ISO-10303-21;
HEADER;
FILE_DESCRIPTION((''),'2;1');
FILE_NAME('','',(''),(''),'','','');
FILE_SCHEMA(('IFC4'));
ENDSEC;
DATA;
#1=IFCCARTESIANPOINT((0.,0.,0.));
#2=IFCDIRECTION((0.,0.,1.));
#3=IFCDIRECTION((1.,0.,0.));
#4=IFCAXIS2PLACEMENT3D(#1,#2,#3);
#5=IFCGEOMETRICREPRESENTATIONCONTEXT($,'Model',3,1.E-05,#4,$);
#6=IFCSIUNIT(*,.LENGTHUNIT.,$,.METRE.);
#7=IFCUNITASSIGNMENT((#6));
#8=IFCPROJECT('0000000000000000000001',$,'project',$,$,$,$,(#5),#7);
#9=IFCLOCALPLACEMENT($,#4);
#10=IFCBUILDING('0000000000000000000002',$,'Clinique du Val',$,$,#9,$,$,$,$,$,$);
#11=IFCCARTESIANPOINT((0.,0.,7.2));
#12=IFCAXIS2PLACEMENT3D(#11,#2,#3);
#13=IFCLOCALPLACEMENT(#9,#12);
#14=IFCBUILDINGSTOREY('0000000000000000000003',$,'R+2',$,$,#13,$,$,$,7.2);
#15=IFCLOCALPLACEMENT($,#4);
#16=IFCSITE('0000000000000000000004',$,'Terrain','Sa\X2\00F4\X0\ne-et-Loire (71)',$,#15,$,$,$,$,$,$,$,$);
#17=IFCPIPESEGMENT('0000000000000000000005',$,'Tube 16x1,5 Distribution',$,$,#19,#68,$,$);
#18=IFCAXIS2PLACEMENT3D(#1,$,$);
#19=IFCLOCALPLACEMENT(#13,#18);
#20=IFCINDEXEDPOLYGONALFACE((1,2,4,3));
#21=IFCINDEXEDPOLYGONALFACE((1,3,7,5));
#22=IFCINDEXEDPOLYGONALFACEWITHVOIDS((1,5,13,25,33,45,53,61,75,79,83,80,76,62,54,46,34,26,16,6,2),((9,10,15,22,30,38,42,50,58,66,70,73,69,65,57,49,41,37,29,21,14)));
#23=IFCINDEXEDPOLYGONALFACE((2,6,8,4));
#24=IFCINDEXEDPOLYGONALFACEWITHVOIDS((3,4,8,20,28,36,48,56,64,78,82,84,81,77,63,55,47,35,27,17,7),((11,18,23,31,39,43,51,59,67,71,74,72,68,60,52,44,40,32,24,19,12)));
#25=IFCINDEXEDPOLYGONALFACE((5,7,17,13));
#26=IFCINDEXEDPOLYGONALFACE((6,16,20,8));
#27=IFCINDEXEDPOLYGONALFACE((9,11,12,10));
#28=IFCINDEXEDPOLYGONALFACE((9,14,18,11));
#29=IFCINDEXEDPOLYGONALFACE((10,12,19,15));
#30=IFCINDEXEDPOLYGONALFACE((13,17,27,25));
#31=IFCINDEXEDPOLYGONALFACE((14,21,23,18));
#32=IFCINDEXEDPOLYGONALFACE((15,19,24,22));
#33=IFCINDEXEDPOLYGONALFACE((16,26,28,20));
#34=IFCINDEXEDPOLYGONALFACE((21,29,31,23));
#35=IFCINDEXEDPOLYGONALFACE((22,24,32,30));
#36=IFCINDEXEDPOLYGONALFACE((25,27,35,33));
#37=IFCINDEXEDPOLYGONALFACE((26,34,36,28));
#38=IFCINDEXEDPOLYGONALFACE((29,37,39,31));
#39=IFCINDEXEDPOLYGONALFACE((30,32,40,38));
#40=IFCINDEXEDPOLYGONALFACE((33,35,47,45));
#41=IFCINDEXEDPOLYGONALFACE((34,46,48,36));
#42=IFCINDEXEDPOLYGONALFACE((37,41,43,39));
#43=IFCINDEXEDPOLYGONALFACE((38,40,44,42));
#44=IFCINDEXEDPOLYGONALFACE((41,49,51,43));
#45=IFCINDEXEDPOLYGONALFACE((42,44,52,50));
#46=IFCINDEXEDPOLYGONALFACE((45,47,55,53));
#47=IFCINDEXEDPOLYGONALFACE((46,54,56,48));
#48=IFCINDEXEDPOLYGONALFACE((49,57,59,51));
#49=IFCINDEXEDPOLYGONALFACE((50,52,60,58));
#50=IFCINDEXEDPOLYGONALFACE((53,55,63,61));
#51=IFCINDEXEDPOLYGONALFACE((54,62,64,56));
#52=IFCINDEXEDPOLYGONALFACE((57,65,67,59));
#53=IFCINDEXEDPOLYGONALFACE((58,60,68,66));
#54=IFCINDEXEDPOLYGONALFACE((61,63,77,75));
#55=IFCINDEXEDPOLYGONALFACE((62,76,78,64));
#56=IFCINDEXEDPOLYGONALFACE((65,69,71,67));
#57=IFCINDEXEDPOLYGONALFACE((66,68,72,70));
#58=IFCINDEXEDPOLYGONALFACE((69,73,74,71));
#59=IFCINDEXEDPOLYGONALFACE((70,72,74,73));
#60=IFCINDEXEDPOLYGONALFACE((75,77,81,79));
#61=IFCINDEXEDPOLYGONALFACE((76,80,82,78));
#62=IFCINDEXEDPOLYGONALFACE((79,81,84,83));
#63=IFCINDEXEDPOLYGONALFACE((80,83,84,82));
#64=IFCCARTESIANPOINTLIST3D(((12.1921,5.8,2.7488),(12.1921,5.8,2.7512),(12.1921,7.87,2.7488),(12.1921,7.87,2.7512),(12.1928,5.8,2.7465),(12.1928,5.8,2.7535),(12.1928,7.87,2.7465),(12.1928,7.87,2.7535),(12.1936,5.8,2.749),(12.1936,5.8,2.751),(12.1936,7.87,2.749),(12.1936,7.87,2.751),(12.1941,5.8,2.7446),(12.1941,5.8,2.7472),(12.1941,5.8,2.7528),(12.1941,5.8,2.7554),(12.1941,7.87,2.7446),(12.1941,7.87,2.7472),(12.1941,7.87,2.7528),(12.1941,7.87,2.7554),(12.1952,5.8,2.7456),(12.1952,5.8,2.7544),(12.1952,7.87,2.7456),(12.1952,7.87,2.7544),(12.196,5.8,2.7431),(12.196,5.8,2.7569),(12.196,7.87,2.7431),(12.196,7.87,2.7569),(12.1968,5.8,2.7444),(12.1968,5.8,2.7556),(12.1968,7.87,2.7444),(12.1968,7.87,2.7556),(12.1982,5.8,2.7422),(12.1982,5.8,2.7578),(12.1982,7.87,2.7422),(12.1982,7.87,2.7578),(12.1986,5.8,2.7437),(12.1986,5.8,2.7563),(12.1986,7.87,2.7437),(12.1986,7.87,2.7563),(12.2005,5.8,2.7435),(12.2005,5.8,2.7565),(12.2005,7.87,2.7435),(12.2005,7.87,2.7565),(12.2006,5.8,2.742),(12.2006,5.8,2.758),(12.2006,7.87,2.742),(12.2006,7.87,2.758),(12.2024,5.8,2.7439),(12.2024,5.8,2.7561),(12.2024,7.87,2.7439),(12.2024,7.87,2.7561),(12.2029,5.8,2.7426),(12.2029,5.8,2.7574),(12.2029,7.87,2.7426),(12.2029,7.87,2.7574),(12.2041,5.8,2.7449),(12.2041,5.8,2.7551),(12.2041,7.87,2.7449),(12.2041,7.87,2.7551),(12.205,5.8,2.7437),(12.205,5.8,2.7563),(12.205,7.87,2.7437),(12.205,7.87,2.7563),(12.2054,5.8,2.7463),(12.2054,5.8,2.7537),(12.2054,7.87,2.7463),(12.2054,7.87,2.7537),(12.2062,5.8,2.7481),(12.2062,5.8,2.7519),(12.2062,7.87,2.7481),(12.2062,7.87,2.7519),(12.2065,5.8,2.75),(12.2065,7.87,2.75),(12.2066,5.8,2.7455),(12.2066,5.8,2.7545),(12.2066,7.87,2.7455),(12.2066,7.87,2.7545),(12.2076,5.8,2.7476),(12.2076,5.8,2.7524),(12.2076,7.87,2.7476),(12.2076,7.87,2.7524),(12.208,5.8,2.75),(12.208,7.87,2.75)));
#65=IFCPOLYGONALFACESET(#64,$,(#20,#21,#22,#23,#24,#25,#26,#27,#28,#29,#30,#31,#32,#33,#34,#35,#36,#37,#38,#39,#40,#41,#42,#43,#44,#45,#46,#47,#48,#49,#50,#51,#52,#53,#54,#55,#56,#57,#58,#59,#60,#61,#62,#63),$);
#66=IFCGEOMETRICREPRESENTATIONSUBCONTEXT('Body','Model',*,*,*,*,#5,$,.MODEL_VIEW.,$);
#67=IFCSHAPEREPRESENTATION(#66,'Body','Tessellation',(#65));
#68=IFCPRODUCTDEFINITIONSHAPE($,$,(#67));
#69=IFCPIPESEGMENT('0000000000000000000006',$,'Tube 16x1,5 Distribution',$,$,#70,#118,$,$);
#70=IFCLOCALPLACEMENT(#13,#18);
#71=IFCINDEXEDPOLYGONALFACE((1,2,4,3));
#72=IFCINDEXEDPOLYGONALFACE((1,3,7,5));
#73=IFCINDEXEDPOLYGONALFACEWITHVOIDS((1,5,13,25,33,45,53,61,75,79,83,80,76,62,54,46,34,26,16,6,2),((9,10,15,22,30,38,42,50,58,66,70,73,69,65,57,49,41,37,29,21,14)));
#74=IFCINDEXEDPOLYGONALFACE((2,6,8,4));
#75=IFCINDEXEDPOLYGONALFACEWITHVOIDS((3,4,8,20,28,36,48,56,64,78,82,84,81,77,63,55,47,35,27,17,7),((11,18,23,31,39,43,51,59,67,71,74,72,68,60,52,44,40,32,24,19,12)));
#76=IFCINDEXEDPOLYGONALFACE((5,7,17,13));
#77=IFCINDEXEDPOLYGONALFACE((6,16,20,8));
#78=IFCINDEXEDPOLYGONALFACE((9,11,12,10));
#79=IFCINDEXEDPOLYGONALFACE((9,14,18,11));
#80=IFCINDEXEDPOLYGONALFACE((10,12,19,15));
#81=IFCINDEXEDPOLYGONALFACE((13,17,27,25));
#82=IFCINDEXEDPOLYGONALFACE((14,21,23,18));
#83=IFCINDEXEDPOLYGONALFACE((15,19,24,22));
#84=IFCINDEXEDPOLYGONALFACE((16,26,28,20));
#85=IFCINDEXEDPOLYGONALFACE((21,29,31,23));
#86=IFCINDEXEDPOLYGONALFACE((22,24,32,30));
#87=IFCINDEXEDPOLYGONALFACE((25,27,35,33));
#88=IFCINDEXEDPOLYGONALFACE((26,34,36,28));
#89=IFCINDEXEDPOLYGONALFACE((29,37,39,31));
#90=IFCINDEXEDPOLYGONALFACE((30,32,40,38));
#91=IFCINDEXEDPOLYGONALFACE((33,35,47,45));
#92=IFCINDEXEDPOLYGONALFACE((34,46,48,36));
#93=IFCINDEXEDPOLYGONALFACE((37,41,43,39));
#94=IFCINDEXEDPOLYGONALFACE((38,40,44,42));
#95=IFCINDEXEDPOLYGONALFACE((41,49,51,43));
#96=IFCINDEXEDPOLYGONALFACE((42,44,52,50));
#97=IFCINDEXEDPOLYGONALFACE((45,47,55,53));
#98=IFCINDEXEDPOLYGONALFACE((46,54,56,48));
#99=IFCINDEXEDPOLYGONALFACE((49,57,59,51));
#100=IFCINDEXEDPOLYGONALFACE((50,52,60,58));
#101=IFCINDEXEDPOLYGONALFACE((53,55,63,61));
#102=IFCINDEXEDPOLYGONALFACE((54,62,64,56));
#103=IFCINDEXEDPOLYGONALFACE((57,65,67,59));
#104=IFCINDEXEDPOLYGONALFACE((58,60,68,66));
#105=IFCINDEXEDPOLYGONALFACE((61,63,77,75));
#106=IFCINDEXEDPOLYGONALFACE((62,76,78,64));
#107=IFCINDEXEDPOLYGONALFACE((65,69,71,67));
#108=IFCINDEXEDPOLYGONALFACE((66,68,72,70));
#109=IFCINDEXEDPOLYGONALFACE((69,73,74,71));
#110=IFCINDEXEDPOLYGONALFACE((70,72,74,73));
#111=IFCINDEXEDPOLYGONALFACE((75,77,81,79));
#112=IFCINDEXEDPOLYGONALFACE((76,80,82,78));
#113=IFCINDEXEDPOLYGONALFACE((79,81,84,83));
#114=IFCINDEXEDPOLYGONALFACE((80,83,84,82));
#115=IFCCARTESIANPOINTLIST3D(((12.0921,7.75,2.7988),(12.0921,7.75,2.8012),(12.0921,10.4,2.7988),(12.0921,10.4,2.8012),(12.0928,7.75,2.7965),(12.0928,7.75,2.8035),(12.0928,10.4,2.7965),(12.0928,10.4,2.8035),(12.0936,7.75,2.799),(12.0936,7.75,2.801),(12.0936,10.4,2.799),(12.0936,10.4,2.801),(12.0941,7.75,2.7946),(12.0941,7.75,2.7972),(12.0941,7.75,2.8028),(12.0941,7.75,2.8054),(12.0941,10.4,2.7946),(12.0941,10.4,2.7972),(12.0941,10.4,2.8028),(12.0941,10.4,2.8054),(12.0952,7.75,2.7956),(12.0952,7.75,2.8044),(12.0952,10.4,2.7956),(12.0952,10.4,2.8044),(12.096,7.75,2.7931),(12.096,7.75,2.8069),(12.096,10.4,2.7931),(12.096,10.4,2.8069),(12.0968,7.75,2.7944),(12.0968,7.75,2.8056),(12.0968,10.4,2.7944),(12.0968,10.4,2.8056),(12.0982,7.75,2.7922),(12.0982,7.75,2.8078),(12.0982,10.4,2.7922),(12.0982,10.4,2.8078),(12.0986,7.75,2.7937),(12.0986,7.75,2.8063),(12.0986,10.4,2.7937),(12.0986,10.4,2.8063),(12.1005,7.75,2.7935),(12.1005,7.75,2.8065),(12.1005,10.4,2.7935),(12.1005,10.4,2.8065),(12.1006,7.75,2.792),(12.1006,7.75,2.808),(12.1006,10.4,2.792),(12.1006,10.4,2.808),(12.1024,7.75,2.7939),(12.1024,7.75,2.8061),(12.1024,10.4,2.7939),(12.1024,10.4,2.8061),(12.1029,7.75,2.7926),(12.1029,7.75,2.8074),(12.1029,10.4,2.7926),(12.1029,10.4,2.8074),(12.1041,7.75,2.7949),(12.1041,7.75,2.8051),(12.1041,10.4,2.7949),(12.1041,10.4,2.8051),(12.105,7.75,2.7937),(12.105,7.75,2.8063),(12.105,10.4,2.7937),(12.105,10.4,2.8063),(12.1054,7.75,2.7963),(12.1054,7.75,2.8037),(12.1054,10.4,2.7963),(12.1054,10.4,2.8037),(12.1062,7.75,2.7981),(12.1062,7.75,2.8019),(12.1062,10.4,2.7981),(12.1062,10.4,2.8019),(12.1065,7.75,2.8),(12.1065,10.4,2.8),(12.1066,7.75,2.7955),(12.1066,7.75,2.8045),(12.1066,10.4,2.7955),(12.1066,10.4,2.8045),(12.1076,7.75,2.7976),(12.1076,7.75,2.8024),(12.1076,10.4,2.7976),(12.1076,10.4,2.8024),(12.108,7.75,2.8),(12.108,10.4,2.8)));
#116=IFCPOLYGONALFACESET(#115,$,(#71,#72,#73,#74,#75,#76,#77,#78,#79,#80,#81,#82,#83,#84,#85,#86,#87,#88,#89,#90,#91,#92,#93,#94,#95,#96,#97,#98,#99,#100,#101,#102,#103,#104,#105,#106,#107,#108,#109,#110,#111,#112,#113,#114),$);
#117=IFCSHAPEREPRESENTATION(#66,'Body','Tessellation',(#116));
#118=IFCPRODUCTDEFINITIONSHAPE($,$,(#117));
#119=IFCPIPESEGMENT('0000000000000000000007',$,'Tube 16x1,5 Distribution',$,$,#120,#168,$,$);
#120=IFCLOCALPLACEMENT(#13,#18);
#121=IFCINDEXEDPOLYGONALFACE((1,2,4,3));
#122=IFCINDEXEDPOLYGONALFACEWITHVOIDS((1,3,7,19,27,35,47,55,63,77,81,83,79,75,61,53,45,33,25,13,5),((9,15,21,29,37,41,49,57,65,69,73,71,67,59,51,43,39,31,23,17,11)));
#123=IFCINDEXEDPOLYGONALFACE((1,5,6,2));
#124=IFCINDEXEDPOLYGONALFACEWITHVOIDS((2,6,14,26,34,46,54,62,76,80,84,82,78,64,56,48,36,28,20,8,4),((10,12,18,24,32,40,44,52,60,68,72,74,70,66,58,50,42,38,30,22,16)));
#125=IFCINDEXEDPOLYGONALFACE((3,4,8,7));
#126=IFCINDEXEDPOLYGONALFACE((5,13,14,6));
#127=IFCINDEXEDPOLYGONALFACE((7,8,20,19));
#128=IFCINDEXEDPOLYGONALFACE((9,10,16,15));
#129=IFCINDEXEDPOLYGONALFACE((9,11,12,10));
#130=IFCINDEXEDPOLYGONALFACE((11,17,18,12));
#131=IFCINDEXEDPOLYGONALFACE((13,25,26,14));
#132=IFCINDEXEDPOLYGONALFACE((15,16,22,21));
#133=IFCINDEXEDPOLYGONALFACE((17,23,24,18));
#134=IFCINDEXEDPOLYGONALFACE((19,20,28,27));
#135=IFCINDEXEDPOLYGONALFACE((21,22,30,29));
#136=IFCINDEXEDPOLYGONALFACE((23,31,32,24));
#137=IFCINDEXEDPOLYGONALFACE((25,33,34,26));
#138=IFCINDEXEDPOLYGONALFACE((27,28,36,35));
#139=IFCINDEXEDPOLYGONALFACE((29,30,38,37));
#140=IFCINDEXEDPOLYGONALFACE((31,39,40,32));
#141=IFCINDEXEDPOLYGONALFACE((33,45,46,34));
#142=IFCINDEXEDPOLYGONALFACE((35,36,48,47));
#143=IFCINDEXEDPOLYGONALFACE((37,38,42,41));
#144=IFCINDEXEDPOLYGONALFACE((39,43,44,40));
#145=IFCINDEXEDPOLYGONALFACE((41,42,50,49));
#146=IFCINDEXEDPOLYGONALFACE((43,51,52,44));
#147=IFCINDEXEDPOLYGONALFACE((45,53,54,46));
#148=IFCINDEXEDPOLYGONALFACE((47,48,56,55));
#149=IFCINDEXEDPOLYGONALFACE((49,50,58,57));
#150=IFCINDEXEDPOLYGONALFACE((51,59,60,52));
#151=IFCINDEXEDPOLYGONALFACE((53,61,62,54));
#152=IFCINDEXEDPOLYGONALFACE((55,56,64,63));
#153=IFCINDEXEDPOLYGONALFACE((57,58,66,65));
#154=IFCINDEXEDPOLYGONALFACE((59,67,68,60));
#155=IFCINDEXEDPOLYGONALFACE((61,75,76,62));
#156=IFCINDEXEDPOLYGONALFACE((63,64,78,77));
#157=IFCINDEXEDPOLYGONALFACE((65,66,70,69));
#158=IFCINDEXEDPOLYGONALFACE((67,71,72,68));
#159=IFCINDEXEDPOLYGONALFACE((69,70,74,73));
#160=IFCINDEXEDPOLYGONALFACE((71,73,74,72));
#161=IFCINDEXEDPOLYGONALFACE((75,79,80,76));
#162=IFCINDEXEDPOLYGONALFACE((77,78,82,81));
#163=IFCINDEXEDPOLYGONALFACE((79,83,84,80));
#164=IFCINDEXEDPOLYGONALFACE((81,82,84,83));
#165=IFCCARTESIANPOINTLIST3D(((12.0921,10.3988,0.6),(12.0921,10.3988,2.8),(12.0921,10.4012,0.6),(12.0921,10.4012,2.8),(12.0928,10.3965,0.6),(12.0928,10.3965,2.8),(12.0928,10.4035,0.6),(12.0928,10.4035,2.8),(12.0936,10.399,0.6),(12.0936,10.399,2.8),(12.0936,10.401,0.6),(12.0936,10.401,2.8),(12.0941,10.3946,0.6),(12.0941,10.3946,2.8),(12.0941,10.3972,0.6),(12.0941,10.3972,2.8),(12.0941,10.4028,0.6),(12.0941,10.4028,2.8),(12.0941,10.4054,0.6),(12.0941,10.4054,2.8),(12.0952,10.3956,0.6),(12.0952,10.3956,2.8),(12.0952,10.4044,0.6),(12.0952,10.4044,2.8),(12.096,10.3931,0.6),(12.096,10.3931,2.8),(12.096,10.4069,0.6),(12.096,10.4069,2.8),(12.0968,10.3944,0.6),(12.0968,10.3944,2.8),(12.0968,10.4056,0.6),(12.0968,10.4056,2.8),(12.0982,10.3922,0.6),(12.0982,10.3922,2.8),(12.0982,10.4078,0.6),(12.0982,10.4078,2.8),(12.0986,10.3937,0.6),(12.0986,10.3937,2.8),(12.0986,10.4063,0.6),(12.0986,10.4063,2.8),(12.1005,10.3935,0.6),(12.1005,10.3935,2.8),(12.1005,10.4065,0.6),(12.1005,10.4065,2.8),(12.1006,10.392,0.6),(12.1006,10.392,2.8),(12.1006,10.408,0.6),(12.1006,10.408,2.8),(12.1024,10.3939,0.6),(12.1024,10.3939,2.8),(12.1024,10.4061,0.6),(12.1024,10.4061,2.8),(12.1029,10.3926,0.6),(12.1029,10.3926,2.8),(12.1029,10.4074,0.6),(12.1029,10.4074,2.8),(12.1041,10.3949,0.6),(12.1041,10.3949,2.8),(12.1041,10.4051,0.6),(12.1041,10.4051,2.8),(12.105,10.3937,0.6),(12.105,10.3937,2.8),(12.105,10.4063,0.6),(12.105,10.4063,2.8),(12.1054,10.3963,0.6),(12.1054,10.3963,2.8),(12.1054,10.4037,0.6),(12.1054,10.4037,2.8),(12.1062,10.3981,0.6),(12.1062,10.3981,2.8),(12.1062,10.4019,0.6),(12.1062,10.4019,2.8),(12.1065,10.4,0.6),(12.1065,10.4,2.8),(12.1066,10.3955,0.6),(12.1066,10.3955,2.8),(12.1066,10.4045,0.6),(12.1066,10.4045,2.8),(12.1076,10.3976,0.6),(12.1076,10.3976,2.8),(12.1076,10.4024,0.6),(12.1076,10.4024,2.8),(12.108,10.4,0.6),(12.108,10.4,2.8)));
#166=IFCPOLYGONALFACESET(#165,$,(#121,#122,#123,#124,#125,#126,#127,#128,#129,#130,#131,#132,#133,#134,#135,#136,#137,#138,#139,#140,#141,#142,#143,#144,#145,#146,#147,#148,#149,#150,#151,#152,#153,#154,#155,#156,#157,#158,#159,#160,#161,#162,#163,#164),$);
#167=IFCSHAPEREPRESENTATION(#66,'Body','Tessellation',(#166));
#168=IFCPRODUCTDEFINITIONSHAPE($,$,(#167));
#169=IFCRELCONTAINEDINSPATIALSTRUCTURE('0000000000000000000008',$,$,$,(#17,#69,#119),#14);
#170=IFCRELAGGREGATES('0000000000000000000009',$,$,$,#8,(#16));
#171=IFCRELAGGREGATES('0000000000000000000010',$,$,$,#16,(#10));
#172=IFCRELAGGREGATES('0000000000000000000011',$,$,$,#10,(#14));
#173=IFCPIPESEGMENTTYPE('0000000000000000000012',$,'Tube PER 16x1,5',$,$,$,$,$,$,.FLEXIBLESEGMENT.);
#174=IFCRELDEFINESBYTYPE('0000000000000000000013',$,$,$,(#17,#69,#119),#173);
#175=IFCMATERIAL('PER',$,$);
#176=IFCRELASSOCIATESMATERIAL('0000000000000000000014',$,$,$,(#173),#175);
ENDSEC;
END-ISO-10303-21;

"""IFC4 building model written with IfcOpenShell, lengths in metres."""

from ifc_helpers import new_model, si_unit, frame, origin_with_axes, place, context, subcontext, project, spatial, hollow_circle, extrude, material, type_object, element, save


model = new_model("IFC4")

# Units and contexts
model_context = context("Model", 3, precision=1e-05, world=origin_with_axes())
body_context = subcontext(model_context, "Body", "Model", "MODEL_VIEW")
ifc_project = project(units=[si_unit("LENGTHUNIT", "METRE")], contexts=[model_context])

# Site, building, storey
site_placement = place(None, origin_with_axes())
site = spatial("IfcSite", under=ifc_project, at=site_placement, Name="Terrain", Description="Saône-et-Loire (71)")
building_placement = place(None, origin_with_axes())
building = spatial("IfcBuilding", under=site, at=building_placement, Name="Clinique du Val")
storey_placement = place(building_placement, frame((0.0, 0.0, 7.2), z_axis=(0.0, 0.0, 1.0), x_axis=(1.0, 0.0, 0.0)))
storey = spatial("IfcBuildingStorey", under=building, at=storey_placement, Name="R+2", Elevation=7.2)

# Pipe segments
ifc_material_1 = material(Name="PER")
pipe_segment_type_1 = type_object("IfcPipeSegmentType", Name="Tube PER 16x1,5", PredefinedType="FLEXIBLESEGMENT", material=ifc_material_1)
pipe_segment_1_placement = place(storey_placement, frame((12.2, 7.87, 2.75), z_axis=(0.0, -1.0, 0.0), x_axis=(1.0, 0.0, 0.0)))
element("IfcPipeSegment", 1, at=pipe_segment_1_placement, inside=storey, type_object=pipe_segment_type_1, Name="Tube 16x1,5 Distribution", context=body_context, shape_type="SweptSolid", body=[
    extrude(hollow_circle(Radius=0.008, WallThickness=0.0015), origin_with_axes(), (0.0, 0.0, 1.0), 2.07),
])
pipe_segment_2_placement = place(storey_placement, frame((12.1, 7.75, 2.8), z_axis=(0.0, 1.0, 0.0), x_axis=(1.0, 0.0, 0.0)))
element("IfcPipeSegment", 2, at=pipe_segment_2_placement, inside=storey, type_object=pipe_segment_type_1, Name="Tube 16x1,5 Distribution", context=body_context, shape_type="SweptSolid", body=[
    extrude(hollow_circle(Radius=0.008, WallThickness=0.0015), origin_with_axes(), (0.0, 0.0, 1.0), 2.65),
])
pipe_segment_3_placement = place(storey_placement, frame((12.1, 10.4, 2.8), z_axis=(0.0, 0.0, -1.0), x_axis=(1.0, 0.0, 0.0)))
element("IfcPipeSegment", 3, at=pipe_segment_3_placement, inside=storey, type_object=pipe_segment_type_1, Name="Tube 16x1,5 Distribution", context=body_context, shape_type="SweptSolid", body=[
    extrude(hollow_circle(Radius=0.008, WallThickness=0.0015), origin_with_axes(), (0.0, 0.0, 1.0), 2.2),
])

save(model, "model.ifc")
